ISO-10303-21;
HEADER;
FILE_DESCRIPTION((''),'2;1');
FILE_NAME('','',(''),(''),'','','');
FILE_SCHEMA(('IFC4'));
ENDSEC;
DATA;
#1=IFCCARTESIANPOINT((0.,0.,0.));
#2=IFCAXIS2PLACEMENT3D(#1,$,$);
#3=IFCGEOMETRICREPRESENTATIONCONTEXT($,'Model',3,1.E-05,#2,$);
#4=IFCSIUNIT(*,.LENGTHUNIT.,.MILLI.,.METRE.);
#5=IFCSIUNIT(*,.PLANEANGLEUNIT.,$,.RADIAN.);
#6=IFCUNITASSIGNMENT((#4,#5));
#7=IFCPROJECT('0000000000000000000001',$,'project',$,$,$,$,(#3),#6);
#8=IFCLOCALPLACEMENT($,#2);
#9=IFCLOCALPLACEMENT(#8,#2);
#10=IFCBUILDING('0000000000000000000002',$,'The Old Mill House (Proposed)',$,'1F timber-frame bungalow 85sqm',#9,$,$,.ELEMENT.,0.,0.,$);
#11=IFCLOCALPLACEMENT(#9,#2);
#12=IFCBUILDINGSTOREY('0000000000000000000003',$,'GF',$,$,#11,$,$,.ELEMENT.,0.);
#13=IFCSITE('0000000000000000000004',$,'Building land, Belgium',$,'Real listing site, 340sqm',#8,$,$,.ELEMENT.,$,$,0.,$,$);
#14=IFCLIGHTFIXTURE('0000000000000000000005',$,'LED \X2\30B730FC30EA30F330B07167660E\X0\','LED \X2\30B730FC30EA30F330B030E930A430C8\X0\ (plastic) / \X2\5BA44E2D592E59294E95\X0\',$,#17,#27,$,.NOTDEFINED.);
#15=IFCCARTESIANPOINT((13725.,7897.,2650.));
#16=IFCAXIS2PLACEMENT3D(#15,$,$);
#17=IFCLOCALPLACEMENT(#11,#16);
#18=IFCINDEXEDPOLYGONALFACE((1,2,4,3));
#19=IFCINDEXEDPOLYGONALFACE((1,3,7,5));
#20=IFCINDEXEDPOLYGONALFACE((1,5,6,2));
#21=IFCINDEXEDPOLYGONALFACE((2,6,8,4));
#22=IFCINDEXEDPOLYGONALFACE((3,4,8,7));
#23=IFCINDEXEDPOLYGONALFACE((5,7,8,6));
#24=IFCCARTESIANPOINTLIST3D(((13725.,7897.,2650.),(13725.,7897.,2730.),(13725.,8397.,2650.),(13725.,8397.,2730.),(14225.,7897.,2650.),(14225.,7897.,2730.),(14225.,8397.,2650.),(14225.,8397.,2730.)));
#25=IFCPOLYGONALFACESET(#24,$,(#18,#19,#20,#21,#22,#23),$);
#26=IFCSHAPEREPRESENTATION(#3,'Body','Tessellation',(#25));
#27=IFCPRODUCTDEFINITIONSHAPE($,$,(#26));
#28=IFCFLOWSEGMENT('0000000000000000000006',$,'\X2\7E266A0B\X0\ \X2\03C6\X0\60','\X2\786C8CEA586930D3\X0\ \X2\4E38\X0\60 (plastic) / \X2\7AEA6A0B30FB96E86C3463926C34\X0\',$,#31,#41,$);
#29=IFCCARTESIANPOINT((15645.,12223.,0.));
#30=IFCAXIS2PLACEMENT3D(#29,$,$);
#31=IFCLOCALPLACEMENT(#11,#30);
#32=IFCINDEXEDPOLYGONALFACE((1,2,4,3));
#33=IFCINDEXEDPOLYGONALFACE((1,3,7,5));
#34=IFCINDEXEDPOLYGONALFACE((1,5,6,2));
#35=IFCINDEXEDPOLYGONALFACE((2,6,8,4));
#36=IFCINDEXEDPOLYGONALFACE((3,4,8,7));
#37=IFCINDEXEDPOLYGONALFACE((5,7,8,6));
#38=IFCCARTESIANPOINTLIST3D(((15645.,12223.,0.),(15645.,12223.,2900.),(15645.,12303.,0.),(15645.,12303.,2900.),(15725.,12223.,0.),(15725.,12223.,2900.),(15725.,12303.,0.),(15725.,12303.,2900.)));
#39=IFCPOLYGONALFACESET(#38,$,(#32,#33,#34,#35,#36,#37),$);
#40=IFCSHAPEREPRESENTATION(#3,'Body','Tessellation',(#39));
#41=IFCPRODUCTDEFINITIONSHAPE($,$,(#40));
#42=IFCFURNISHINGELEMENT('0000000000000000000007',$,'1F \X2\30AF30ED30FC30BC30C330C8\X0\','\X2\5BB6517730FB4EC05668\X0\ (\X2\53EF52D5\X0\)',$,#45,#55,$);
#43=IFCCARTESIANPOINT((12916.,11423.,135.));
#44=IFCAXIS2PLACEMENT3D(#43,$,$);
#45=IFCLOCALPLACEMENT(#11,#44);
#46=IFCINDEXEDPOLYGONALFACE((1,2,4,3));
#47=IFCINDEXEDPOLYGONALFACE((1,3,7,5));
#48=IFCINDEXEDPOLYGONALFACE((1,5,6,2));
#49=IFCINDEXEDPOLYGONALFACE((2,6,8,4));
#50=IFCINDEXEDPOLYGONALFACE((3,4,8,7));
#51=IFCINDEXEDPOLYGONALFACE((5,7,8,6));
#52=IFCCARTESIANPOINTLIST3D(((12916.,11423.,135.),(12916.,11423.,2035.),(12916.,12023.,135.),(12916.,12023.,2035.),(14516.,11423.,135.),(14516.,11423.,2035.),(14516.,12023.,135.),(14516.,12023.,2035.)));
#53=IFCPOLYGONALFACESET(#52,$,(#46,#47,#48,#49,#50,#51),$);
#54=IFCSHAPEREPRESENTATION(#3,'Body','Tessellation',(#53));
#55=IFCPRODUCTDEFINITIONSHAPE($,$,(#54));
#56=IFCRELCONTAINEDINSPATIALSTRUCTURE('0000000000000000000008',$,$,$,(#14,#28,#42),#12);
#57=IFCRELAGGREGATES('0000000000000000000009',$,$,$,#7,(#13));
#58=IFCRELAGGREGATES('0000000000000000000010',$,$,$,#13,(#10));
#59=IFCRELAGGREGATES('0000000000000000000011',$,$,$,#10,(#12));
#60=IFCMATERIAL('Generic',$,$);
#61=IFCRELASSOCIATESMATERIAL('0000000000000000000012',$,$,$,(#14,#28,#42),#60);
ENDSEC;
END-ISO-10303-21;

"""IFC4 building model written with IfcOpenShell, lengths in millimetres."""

from ifc_helpers import new_model, si_unit, frame, frame_2d, origin, place, context, project, spatial, rectangle, extrude, material, element, save


model = new_model("IFC4")

# Units and contexts
model_context = context("Model", 3, precision=1e-05, world=origin())
ifc_project = project(units=[si_unit("LENGTHUNIT", "METRE", prefix="MILLI"), si_unit("PLANEANGLEUNIT", "RADIAN")], contexts=[model_context])

# Site, building, storey
site_placement = place(None, origin())
site = spatial("IfcSite", under=ifc_project, at=site_placement, Name="Building land, Belgium", ObjectType="Real listing site, 340sqm", CompositionType="ELEMENT", RefElevation=0.0)
building_placement = place(site_placement, origin())
building = spatial("IfcBuilding", under=site, at=building_placement, Name="The Old Mill House (Proposed)", ObjectType="1F timber-frame bungalow 85sqm", CompositionType="ELEMENT", ElevationOfRefHeight=0.0, ElevationOfTerrain=0.0)
storey_placement = place(building_placement, origin())
storey = spatial("IfcBuildingStorey", under=building, at=storey_placement, Name="GF", CompositionType="ELEMENT", Elevation=0.0)

# Shared definitions
ifc_material_1 = material(Name="Generic")

# Light fixture
light_fixture_1_placement = place(storey_placement, frame((13725.0, 7897.0, 2650.0)))
element("IfcLightFixture", 1, at=light_fixture_1_placement, inside=storey, material=ifc_material_1, Name="LED シーリング照明", Description="LED シーリングライト (plastic) / 室中央天井", PredefinedType="NOTDEFINED", context=model_context, shape_type="SweptSolid", body=[
    extrude(rectangle(XDim=500.0, YDim=500.0, at=frame_2d((250.0, 250.0))), frame((13725.0, 7897.0, 2650.0)), (0.0, 0.0, 1.0), 80.0),
])

# Flow segment
flow_segment_placement = place(storey_placement, frame((15645.0, 12223.0, 0.0)))
element("IfcFlowSegment", 2, at=flow_segment_placement, inside=storey, material=ifc_material_1, Name="縦樋 φ60", Description="硬質塩ビ 丸60 (plastic) / 竪樋・雨水排水", context=model_context, shape_type="SweptSolid", body=[
    extrude(rectangle(XDim=80.0, YDim=80.0, at=frame_2d((40.0, 40.0))), frame((15645.0, 12223.0, 0.0)), (0.0, 0.0, 1.0), 2900.0),
])

# Furnishing element
furnishing_placement = place(storey_placement, frame((12916.0, 11423.0, 135.0)))
element("IfcFurnishingElement", 3, at=furnishing_placement, inside=storey, material=ifc_material_1, Name="1F クローゼット", Description="家具・什器 (可動)", context=model_context, shape_type="SweptSolid", body=[
    extrude(rectangle(XDim=1600.0, YDim=600.0, at=frame_2d((800.0, 300.0))), frame((12916.0, 11423.0, 135.0)), (0.0, 0.0, 1.0), 1900.0),
])

save(model, "model.ifc")
